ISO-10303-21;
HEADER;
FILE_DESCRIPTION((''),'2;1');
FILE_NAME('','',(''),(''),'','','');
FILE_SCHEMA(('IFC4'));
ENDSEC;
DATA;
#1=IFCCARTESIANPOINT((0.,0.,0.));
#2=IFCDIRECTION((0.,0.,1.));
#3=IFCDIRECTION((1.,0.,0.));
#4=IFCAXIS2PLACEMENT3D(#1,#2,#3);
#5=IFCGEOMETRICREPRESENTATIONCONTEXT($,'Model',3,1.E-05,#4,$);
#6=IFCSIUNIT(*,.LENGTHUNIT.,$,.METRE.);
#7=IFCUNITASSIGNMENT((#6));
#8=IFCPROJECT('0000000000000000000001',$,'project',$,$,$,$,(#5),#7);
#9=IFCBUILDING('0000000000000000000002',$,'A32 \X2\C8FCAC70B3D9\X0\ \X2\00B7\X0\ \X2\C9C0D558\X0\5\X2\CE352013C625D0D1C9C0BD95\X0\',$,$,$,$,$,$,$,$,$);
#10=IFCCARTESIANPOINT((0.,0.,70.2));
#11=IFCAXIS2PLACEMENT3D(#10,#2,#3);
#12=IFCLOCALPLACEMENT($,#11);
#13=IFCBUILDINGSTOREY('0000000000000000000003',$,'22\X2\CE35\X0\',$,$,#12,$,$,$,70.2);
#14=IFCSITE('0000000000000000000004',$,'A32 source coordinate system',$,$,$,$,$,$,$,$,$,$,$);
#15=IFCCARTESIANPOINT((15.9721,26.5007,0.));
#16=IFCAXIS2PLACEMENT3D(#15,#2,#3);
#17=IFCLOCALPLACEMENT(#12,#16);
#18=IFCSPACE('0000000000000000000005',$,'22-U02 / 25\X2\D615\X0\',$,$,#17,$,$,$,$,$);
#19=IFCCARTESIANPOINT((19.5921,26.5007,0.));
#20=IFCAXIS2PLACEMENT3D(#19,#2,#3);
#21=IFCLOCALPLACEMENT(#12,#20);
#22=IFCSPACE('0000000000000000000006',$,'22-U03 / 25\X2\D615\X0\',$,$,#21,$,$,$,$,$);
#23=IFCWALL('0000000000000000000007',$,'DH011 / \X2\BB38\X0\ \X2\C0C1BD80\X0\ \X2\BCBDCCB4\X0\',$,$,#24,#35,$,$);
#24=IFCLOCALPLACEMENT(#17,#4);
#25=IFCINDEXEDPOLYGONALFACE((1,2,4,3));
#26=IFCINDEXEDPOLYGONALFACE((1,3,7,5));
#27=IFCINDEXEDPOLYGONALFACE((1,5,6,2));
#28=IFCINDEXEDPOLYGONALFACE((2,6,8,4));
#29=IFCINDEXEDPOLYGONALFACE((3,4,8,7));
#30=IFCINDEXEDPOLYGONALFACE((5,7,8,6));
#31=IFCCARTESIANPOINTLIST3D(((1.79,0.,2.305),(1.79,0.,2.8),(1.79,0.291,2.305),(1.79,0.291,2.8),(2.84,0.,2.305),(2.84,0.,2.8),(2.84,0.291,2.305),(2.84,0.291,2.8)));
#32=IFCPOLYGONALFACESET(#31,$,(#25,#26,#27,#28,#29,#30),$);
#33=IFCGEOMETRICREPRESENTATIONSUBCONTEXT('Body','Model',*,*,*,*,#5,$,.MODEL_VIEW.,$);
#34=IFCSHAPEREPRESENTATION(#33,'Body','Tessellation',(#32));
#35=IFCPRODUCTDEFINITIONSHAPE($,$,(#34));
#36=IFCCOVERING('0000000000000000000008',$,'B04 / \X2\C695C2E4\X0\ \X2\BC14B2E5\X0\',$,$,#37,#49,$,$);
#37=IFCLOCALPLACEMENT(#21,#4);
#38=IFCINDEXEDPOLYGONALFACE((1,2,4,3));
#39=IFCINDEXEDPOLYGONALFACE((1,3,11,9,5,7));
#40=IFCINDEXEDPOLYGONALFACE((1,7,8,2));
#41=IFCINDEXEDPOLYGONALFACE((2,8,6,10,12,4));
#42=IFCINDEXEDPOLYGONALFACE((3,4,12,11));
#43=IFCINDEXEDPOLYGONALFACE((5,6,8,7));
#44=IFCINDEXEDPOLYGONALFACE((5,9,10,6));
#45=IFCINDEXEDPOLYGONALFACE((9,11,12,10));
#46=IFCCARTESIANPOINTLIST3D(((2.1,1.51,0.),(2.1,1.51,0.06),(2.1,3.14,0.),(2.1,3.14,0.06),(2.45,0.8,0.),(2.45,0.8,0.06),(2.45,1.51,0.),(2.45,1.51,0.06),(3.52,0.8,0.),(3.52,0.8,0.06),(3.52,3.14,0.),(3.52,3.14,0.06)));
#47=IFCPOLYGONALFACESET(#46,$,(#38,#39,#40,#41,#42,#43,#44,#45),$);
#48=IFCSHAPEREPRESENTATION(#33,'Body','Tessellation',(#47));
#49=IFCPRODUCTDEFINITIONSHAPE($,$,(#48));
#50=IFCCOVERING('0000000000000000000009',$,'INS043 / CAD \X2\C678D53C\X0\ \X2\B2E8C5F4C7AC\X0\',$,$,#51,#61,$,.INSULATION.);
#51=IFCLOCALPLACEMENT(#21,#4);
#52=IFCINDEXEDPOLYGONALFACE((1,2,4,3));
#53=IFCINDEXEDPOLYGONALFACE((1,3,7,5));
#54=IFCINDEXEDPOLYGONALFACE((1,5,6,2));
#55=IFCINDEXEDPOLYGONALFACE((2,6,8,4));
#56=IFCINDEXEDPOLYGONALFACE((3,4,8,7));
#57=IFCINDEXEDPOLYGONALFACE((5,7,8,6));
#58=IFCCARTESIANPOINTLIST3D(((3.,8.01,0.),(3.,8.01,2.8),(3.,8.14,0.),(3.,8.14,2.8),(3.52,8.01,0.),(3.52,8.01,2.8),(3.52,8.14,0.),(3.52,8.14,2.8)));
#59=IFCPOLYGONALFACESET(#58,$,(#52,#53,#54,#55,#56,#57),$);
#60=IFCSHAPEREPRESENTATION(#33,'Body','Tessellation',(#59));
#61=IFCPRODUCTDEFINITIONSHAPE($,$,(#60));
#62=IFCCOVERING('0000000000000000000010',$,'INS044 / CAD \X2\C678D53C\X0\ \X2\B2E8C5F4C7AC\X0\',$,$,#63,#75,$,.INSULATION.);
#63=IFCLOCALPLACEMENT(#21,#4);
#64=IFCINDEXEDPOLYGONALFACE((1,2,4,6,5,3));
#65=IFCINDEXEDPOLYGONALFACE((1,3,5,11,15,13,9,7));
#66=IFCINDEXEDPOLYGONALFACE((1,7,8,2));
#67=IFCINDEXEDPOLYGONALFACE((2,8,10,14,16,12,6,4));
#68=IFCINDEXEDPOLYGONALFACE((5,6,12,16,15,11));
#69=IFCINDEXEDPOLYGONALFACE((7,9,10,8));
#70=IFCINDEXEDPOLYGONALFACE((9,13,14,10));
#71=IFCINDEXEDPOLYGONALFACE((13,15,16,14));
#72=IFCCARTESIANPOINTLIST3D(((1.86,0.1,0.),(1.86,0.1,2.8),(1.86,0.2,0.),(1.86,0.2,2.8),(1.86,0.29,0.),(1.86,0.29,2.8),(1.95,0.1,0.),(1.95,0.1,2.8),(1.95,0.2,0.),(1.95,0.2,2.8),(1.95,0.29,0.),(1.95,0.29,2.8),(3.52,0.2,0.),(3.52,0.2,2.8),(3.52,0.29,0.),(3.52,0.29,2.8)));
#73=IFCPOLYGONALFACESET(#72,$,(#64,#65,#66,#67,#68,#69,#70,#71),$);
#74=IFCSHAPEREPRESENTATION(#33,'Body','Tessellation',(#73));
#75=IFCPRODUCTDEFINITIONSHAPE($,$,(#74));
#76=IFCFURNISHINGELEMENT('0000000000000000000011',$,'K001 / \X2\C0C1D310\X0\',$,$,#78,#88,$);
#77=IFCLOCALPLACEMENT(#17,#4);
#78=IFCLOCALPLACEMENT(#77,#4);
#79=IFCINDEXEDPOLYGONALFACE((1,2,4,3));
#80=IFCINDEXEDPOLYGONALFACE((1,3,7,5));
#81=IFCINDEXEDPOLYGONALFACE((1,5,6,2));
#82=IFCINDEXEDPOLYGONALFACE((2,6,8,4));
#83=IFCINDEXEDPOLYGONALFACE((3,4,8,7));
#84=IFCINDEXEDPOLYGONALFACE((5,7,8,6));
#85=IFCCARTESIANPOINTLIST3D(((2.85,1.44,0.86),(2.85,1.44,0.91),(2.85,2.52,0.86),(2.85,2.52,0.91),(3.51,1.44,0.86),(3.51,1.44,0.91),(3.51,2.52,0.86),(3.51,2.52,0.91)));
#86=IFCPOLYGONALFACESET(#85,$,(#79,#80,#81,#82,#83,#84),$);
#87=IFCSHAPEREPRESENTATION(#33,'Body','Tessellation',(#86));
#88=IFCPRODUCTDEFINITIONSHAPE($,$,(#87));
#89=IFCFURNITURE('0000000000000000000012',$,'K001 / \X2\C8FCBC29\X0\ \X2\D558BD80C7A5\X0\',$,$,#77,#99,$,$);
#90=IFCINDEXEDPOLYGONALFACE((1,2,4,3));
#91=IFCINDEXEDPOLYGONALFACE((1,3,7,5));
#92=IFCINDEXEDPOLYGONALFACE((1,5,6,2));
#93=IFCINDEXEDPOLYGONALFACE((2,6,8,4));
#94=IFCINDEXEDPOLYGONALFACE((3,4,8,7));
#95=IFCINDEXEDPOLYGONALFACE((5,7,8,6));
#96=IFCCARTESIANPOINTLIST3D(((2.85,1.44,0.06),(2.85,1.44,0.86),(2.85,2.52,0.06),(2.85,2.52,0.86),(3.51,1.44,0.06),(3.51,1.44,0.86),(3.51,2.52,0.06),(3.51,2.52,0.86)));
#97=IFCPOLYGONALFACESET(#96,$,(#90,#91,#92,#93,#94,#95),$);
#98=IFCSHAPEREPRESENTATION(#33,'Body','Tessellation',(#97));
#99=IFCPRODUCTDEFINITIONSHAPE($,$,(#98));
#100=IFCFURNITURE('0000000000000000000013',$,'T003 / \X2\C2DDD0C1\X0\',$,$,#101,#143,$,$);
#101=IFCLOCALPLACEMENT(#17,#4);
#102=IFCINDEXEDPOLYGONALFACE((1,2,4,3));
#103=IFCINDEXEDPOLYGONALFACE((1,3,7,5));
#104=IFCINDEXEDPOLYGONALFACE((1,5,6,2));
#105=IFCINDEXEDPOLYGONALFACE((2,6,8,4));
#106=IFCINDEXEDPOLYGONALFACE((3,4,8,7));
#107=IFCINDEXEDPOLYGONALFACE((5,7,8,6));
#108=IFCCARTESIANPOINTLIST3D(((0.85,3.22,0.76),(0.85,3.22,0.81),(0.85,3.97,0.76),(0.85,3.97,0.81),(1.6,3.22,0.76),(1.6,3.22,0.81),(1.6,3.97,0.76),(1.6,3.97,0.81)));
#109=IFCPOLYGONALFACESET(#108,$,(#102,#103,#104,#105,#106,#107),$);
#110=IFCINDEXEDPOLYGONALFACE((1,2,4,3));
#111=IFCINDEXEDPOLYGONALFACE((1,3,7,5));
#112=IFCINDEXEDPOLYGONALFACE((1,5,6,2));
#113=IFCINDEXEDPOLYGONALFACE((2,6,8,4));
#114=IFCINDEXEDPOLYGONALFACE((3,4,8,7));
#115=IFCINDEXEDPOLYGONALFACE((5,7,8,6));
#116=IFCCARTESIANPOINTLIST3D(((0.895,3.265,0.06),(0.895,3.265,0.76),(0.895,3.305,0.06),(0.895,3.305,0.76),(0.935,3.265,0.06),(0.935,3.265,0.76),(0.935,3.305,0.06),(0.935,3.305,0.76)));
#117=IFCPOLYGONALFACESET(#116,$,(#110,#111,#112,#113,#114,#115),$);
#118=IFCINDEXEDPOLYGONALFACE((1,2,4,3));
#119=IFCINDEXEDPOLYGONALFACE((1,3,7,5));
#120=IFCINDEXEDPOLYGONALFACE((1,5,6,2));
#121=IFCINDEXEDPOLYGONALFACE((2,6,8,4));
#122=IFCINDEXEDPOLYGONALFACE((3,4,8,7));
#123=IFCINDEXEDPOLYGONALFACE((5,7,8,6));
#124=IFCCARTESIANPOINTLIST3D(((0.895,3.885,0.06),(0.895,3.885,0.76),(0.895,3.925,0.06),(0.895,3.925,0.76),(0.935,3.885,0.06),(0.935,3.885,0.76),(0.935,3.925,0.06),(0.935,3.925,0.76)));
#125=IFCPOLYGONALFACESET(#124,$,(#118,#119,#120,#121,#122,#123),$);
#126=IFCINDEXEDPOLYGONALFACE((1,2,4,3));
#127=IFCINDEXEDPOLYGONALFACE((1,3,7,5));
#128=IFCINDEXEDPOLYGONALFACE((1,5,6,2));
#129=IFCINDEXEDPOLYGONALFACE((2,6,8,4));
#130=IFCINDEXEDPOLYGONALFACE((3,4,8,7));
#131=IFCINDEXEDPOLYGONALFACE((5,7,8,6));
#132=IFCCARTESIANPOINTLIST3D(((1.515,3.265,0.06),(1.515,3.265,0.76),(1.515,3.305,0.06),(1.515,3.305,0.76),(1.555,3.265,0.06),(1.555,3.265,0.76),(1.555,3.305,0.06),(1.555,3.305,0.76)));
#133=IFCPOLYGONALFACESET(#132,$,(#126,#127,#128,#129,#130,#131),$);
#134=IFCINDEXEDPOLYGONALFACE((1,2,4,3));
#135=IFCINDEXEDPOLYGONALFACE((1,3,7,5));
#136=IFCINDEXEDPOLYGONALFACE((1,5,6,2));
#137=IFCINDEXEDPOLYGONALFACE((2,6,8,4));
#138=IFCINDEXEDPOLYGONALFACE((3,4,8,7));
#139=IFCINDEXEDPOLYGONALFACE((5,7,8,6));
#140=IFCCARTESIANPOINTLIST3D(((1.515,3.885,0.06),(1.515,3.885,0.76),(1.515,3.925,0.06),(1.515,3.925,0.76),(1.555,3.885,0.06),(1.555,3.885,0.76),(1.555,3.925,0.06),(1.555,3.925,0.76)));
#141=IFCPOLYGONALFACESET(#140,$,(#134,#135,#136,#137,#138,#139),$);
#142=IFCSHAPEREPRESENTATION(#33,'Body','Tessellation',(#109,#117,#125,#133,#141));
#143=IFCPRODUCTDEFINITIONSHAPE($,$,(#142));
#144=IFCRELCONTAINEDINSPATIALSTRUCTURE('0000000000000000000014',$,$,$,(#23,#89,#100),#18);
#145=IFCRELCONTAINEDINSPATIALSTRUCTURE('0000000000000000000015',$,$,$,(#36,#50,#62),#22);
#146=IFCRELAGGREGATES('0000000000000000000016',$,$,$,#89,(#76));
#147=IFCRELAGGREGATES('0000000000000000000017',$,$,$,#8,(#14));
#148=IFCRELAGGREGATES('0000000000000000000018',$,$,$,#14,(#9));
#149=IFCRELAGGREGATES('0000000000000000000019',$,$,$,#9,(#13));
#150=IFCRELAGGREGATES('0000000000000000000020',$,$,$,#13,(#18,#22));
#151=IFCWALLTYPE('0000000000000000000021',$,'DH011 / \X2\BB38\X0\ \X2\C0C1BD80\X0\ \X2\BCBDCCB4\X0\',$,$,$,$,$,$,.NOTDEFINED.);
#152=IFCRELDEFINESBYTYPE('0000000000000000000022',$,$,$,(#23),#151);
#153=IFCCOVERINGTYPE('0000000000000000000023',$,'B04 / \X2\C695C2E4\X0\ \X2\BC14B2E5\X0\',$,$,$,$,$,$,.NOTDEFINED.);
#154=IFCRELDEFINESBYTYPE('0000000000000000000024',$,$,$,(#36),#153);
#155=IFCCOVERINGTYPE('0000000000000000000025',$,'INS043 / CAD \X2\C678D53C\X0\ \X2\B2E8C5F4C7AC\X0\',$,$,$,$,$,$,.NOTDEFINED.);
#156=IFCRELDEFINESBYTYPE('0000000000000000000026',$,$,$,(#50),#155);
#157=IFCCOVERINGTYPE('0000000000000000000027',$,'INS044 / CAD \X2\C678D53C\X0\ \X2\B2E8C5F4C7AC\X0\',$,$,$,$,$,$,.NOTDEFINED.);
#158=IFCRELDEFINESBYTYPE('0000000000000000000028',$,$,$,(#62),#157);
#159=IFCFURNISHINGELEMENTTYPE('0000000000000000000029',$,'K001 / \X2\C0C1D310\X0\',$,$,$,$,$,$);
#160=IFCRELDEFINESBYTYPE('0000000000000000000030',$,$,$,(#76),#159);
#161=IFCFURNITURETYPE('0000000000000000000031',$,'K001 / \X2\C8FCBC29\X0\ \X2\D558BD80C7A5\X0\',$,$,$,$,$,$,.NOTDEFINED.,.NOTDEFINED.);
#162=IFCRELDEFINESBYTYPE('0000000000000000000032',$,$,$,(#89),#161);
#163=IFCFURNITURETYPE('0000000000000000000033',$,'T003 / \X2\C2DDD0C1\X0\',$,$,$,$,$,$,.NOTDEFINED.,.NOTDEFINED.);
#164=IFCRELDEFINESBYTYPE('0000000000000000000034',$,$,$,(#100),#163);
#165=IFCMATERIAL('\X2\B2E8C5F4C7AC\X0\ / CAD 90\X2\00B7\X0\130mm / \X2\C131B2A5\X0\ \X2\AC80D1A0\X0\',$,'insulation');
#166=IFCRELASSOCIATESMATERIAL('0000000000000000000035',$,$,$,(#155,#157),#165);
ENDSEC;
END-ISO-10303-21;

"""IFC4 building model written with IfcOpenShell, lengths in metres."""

from ifc_helpers import new_model, si_unit, frame, origin, origin_with_axes, place, context, subcontext, project, spatial, polyline, outline, extrude, source, transform, mapped, material, type_object, type_shapes, element, aggregate, save


model = new_model("IFC4")

# Units and contexts
model_context = context("Model", 3, precision=1e-05, world=origin_with_axes())
body_context = subcontext(model_context, "Body", "Model", "MODEL_VIEW")
ifc_project = project(units=[si_unit("LENGTHUNIT", "METRE")], contexts=[model_context])

# Site, building, storey, space
site = spatial("IfcSite", under=ifc_project, Name="A32 source coordinate system")
building = spatial("IfcBuilding", under=site, Name="A32 주거동 · 지하5층–옥탑지붕")
storey_placement = place(None, frame((0.0, 0.0, 70.2), z_axis=(0.0, 0.0, 1.0), x_axis=(1.0, 0.0, 0.0)))
storey = spatial("IfcBuildingStorey", under=building, at=storey_placement, Name="22층", Elevation=70.2)
space_1_placement = place(storey_placement, frame((15.9721, 26.5007, 0.0), z_axis=(0.0, 0.0, 1.0), x_axis=(1.0, 0.0, 0.0)))
space_1 = spatial("IfcSpace", under=storey, at=space_1_placement, Name="22-U02 / 25형")

# Wall
wall_type_1 = type_object("IfcWallType", Name="DH011 / 문 상부 벽체", PredefinedType="NOTDEFINED")
shared_shape_1 = source(origin(), body_context, "Body", "SweptSolid", [
    extrude(outline(polyline([(2.84, 0.0), (1.79, 0.0), (1.79, 0.291), (2.84, 0.291), (2.84, 0.0)])), frame((0.0, 0.0, 2.305)), (0.0, 0.0, 1.0), 0.495),
])
type_shapes(wall_type_1, [shared_shape_1])
wall_1_placement = place(space_1_placement, origin_with_axes())
element("IfcWall", 1, at=wall_1_placement, inside=space_1, type_object=wall_type_1, Name="DH011 / 문 상부 벽체", context=body_context, shape_type="MappedRepresentation", body=[
    mapped(shared_shape_1, transform((0.0, 0.0, 0.0), scale=1.0)),
])

# Shared definitions
space_2_placement = place(storey_placement, frame((19.5921, 26.5007, 0.0), z_axis=(0.0, 0.0, 1.0), x_axis=(1.0, 0.0, 0.0)))
space_2 = spatial("IfcSpace", under=storey, at=space_2_placement, Name="22-U03 / 25형")

# Coverings
covering_type_1 = type_object("IfcCoveringType", Name="B04 / 욕실 바닥", PredefinedType="NOTDEFINED")
shared_shape_2 = source(origin(), body_context, "Body", "SweptSolid", [
    extrude(outline(polyline([(2.1, 1.51), (2.1, 3.14), (3.52, 3.14), (3.52, 0.8), (2.45, 0.8), (2.45, 1.51), (2.1, 1.51)])), origin(), (0.0, 0.0, 1.0), 0.06),
])
type_shapes(covering_type_1, [shared_shape_2])
covering_1_placement = place(space_2_placement, origin_with_axes())
element("IfcCovering", 2, at=covering_1_placement, inside=space_2, type_object=covering_type_1, Name="B04 / 욕실 바닥", context=body_context, shape_type="MappedRepresentation", body=[
    mapped(shared_shape_2, transform((0.0, 0.0, 0.0), scale=1.0)),
])
ifc_material = material(Name="단열재 / CAD 90·130mm / 성능 검토", Category="insulation")
covering_type_2 = type_object("IfcCoveringType", Name="INS043 / CAD 외피 단열재", PredefinedType="NOTDEFINED", material=ifc_material)
shared_shape_3 = source(origin(), body_context, "Body", "SweptSolid", [
    extrude(outline(polyline([(3.52, 8.14), (3.52, 8.01), (3.0, 8.01), (3.0, 8.14), (3.52, 8.14)])), origin(), (0.0, 0.0, 1.0), 2.8),
])
type_shapes(covering_type_2, [shared_shape_3])
covering_2_placement = place(space_2_placement, origin_with_axes())
element("IfcCovering", 3, at=covering_2_placement, inside=space_2, type_object=covering_type_2, Name="INS043 / CAD 외피 단열재", PredefinedType="INSULATION", context=body_context, shape_type="MappedRepresentation", body=[
    mapped(shared_shape_3, transform((0.0, 0.0, 0.0), scale=1.0)),
])
covering_type_3 = type_object("IfcCoveringType", Name="INS044 / CAD 외피 단열재", PredefinedType="NOTDEFINED", material=ifc_material)
shared_shape_4 = source(origin(), body_context, "Body", "SweptSolid", [
    extrude(outline(polyline([(1.86, 0.2), (1.86, 0.29), (1.95, 0.29), (3.52, 0.29), (3.52, 0.2), (1.95, 0.2), (1.95, 0.1), (1.86, 0.1), (1.86, 0.2)])), origin(), (0.0, 0.0, 1.0), 2.8),
])
type_shapes(covering_type_3, [shared_shape_4])
covering_3_placement = place(space_2_placement, origin_with_axes())
element("IfcCovering", 4, at=covering_3_placement, inside=space_2, type_object=covering_type_3, Name="INS044 / CAD 외피 단열재", PredefinedType="INSULATION", context=body_context, shape_type="MappedRepresentation", body=[
    mapped(shared_shape_4, transform((0.0, 0.0, 0.0), scale=1.0)),
])

# Furnishing element
furnishing_element_type_1 = type_object("IfcFurnishingElementType", Name="K001 / 상판")
shared_shape_5 = source(origin(), body_context, "Body", "SweptSolid", [
    extrude(outline(polyline([(2.85, 2.52), (3.51, 2.52), (3.51, 1.44), (2.85, 1.44), (2.85, 2.52)])), frame((0.0, 0.0, 0.86)), (0.0, 0.0, 1.0), 0.05),
])
type_shapes(furnishing_element_type_1, [shared_shape_5])
furniture_1_placement = place(space_1_placement, origin_with_axes())
furnishing_1_placement = place(furniture_1_placement, origin_with_axes())
furnishing_1 = element("IfcFurnishingElement", 5, at=furnishing_1_placement, type_object=furnishing_element_type_1, Name="K001 / 상판", context=body_context, shape_type="MappedRepresentation", body=[
    mapped(shared_shape_5, transform((0.0, 0.0, 0.0), scale=1.0)),
])

# Furniture
furniture_type_1 = type_object("IfcFurnitureType", Name="K001 / 주방 하부장", AssemblyPlace="NOTDEFINED", PredefinedType="NOTDEFINED")
shared_shape_6 = source(origin(), body_context, "Body", "SweptSolid", [
    extrude(outline(polyline([(2.85, 1.44), (2.85, 2.52), (3.51, 2.52), (3.51, 1.44), (2.85, 1.44)])), frame((0.0, 0.0, 0.06)), (0.0, 0.0, 1.0), 0.8),
])
type_shapes(furniture_type_1, [shared_shape_6])
furniture_1 = element("IfcFurniture", 6, at=furniture_1_placement, inside=space_1, type_object=furniture_type_1, Name="K001 / 주방 하부장", context=body_context, shape_type="MappedRepresentation", body=[
    mapped(shared_shape_6, transform((0.0, 0.0, 0.0), scale=1.0)),
])
aggregate(furniture_1, [furnishing_1])
furniture_type_2 = type_object("IfcFurnitureType", Name="T003 / 식탁", AssemblyPlace="NOTDEFINED", PredefinedType="NOTDEFINED")
shared_shape_7 = source(origin(), body_context, "Body", "SweptSolid", [
    extrude(outline(polyline([(1.6, 3.97), (1.6, 3.22), (0.85, 3.22), (0.85, 3.97), (1.6, 3.97)])), frame((0.0, 0.0, 0.76)), (0.0, 0.0, 1.0), 0.05),
    extrude(outline(polyline([(0.895, 3.265), (0.895, 3.305), (0.935, 3.305), (0.935, 3.265), (0.895, 3.265)])), frame((0.0, 0.0, 0.06)), (0.0, 0.0, 1.0), 0.7),
    extrude(outline(polyline([(0.895, 3.885), (0.895, 3.925), (0.935, 3.925), (0.935, 3.885), (0.895, 3.885)])), frame((0.0, 0.0, 0.06)), (0.0, 0.0, 1.0), 0.7),
    extrude(outline(polyline([(1.515, 3.265), (1.515, 3.305), (1.555, 3.305), (1.555, 3.265), (1.515, 3.265)])), frame((0.0, 0.0, 0.06)), (0.0, 0.0, 1.0), 0.7),
    extrude(outline(polyline([(1.515, 3.885), (1.515, 3.925), (1.555, 3.925), (1.555, 3.885), (1.515, 3.885)])), frame((0.0, 0.0, 0.06)), (0.0, 0.0, 1.0), 0.7),
])
type_shapes(furniture_type_2, [shared_shape_7])
furniture_2_placement = place(space_1_placement, origin_with_axes())
element("IfcFurniture", 7, at=furniture_2_placement, inside=space_1, type_object=furniture_type_2, Name="T003 / 식탁", context=body_context, shape_type="MappedRepresentation", body=[
    mapped(shared_shape_7, transform((0.0, 0.0, 0.0), scale=1.0)),
])

save(model, "model.ifc")
